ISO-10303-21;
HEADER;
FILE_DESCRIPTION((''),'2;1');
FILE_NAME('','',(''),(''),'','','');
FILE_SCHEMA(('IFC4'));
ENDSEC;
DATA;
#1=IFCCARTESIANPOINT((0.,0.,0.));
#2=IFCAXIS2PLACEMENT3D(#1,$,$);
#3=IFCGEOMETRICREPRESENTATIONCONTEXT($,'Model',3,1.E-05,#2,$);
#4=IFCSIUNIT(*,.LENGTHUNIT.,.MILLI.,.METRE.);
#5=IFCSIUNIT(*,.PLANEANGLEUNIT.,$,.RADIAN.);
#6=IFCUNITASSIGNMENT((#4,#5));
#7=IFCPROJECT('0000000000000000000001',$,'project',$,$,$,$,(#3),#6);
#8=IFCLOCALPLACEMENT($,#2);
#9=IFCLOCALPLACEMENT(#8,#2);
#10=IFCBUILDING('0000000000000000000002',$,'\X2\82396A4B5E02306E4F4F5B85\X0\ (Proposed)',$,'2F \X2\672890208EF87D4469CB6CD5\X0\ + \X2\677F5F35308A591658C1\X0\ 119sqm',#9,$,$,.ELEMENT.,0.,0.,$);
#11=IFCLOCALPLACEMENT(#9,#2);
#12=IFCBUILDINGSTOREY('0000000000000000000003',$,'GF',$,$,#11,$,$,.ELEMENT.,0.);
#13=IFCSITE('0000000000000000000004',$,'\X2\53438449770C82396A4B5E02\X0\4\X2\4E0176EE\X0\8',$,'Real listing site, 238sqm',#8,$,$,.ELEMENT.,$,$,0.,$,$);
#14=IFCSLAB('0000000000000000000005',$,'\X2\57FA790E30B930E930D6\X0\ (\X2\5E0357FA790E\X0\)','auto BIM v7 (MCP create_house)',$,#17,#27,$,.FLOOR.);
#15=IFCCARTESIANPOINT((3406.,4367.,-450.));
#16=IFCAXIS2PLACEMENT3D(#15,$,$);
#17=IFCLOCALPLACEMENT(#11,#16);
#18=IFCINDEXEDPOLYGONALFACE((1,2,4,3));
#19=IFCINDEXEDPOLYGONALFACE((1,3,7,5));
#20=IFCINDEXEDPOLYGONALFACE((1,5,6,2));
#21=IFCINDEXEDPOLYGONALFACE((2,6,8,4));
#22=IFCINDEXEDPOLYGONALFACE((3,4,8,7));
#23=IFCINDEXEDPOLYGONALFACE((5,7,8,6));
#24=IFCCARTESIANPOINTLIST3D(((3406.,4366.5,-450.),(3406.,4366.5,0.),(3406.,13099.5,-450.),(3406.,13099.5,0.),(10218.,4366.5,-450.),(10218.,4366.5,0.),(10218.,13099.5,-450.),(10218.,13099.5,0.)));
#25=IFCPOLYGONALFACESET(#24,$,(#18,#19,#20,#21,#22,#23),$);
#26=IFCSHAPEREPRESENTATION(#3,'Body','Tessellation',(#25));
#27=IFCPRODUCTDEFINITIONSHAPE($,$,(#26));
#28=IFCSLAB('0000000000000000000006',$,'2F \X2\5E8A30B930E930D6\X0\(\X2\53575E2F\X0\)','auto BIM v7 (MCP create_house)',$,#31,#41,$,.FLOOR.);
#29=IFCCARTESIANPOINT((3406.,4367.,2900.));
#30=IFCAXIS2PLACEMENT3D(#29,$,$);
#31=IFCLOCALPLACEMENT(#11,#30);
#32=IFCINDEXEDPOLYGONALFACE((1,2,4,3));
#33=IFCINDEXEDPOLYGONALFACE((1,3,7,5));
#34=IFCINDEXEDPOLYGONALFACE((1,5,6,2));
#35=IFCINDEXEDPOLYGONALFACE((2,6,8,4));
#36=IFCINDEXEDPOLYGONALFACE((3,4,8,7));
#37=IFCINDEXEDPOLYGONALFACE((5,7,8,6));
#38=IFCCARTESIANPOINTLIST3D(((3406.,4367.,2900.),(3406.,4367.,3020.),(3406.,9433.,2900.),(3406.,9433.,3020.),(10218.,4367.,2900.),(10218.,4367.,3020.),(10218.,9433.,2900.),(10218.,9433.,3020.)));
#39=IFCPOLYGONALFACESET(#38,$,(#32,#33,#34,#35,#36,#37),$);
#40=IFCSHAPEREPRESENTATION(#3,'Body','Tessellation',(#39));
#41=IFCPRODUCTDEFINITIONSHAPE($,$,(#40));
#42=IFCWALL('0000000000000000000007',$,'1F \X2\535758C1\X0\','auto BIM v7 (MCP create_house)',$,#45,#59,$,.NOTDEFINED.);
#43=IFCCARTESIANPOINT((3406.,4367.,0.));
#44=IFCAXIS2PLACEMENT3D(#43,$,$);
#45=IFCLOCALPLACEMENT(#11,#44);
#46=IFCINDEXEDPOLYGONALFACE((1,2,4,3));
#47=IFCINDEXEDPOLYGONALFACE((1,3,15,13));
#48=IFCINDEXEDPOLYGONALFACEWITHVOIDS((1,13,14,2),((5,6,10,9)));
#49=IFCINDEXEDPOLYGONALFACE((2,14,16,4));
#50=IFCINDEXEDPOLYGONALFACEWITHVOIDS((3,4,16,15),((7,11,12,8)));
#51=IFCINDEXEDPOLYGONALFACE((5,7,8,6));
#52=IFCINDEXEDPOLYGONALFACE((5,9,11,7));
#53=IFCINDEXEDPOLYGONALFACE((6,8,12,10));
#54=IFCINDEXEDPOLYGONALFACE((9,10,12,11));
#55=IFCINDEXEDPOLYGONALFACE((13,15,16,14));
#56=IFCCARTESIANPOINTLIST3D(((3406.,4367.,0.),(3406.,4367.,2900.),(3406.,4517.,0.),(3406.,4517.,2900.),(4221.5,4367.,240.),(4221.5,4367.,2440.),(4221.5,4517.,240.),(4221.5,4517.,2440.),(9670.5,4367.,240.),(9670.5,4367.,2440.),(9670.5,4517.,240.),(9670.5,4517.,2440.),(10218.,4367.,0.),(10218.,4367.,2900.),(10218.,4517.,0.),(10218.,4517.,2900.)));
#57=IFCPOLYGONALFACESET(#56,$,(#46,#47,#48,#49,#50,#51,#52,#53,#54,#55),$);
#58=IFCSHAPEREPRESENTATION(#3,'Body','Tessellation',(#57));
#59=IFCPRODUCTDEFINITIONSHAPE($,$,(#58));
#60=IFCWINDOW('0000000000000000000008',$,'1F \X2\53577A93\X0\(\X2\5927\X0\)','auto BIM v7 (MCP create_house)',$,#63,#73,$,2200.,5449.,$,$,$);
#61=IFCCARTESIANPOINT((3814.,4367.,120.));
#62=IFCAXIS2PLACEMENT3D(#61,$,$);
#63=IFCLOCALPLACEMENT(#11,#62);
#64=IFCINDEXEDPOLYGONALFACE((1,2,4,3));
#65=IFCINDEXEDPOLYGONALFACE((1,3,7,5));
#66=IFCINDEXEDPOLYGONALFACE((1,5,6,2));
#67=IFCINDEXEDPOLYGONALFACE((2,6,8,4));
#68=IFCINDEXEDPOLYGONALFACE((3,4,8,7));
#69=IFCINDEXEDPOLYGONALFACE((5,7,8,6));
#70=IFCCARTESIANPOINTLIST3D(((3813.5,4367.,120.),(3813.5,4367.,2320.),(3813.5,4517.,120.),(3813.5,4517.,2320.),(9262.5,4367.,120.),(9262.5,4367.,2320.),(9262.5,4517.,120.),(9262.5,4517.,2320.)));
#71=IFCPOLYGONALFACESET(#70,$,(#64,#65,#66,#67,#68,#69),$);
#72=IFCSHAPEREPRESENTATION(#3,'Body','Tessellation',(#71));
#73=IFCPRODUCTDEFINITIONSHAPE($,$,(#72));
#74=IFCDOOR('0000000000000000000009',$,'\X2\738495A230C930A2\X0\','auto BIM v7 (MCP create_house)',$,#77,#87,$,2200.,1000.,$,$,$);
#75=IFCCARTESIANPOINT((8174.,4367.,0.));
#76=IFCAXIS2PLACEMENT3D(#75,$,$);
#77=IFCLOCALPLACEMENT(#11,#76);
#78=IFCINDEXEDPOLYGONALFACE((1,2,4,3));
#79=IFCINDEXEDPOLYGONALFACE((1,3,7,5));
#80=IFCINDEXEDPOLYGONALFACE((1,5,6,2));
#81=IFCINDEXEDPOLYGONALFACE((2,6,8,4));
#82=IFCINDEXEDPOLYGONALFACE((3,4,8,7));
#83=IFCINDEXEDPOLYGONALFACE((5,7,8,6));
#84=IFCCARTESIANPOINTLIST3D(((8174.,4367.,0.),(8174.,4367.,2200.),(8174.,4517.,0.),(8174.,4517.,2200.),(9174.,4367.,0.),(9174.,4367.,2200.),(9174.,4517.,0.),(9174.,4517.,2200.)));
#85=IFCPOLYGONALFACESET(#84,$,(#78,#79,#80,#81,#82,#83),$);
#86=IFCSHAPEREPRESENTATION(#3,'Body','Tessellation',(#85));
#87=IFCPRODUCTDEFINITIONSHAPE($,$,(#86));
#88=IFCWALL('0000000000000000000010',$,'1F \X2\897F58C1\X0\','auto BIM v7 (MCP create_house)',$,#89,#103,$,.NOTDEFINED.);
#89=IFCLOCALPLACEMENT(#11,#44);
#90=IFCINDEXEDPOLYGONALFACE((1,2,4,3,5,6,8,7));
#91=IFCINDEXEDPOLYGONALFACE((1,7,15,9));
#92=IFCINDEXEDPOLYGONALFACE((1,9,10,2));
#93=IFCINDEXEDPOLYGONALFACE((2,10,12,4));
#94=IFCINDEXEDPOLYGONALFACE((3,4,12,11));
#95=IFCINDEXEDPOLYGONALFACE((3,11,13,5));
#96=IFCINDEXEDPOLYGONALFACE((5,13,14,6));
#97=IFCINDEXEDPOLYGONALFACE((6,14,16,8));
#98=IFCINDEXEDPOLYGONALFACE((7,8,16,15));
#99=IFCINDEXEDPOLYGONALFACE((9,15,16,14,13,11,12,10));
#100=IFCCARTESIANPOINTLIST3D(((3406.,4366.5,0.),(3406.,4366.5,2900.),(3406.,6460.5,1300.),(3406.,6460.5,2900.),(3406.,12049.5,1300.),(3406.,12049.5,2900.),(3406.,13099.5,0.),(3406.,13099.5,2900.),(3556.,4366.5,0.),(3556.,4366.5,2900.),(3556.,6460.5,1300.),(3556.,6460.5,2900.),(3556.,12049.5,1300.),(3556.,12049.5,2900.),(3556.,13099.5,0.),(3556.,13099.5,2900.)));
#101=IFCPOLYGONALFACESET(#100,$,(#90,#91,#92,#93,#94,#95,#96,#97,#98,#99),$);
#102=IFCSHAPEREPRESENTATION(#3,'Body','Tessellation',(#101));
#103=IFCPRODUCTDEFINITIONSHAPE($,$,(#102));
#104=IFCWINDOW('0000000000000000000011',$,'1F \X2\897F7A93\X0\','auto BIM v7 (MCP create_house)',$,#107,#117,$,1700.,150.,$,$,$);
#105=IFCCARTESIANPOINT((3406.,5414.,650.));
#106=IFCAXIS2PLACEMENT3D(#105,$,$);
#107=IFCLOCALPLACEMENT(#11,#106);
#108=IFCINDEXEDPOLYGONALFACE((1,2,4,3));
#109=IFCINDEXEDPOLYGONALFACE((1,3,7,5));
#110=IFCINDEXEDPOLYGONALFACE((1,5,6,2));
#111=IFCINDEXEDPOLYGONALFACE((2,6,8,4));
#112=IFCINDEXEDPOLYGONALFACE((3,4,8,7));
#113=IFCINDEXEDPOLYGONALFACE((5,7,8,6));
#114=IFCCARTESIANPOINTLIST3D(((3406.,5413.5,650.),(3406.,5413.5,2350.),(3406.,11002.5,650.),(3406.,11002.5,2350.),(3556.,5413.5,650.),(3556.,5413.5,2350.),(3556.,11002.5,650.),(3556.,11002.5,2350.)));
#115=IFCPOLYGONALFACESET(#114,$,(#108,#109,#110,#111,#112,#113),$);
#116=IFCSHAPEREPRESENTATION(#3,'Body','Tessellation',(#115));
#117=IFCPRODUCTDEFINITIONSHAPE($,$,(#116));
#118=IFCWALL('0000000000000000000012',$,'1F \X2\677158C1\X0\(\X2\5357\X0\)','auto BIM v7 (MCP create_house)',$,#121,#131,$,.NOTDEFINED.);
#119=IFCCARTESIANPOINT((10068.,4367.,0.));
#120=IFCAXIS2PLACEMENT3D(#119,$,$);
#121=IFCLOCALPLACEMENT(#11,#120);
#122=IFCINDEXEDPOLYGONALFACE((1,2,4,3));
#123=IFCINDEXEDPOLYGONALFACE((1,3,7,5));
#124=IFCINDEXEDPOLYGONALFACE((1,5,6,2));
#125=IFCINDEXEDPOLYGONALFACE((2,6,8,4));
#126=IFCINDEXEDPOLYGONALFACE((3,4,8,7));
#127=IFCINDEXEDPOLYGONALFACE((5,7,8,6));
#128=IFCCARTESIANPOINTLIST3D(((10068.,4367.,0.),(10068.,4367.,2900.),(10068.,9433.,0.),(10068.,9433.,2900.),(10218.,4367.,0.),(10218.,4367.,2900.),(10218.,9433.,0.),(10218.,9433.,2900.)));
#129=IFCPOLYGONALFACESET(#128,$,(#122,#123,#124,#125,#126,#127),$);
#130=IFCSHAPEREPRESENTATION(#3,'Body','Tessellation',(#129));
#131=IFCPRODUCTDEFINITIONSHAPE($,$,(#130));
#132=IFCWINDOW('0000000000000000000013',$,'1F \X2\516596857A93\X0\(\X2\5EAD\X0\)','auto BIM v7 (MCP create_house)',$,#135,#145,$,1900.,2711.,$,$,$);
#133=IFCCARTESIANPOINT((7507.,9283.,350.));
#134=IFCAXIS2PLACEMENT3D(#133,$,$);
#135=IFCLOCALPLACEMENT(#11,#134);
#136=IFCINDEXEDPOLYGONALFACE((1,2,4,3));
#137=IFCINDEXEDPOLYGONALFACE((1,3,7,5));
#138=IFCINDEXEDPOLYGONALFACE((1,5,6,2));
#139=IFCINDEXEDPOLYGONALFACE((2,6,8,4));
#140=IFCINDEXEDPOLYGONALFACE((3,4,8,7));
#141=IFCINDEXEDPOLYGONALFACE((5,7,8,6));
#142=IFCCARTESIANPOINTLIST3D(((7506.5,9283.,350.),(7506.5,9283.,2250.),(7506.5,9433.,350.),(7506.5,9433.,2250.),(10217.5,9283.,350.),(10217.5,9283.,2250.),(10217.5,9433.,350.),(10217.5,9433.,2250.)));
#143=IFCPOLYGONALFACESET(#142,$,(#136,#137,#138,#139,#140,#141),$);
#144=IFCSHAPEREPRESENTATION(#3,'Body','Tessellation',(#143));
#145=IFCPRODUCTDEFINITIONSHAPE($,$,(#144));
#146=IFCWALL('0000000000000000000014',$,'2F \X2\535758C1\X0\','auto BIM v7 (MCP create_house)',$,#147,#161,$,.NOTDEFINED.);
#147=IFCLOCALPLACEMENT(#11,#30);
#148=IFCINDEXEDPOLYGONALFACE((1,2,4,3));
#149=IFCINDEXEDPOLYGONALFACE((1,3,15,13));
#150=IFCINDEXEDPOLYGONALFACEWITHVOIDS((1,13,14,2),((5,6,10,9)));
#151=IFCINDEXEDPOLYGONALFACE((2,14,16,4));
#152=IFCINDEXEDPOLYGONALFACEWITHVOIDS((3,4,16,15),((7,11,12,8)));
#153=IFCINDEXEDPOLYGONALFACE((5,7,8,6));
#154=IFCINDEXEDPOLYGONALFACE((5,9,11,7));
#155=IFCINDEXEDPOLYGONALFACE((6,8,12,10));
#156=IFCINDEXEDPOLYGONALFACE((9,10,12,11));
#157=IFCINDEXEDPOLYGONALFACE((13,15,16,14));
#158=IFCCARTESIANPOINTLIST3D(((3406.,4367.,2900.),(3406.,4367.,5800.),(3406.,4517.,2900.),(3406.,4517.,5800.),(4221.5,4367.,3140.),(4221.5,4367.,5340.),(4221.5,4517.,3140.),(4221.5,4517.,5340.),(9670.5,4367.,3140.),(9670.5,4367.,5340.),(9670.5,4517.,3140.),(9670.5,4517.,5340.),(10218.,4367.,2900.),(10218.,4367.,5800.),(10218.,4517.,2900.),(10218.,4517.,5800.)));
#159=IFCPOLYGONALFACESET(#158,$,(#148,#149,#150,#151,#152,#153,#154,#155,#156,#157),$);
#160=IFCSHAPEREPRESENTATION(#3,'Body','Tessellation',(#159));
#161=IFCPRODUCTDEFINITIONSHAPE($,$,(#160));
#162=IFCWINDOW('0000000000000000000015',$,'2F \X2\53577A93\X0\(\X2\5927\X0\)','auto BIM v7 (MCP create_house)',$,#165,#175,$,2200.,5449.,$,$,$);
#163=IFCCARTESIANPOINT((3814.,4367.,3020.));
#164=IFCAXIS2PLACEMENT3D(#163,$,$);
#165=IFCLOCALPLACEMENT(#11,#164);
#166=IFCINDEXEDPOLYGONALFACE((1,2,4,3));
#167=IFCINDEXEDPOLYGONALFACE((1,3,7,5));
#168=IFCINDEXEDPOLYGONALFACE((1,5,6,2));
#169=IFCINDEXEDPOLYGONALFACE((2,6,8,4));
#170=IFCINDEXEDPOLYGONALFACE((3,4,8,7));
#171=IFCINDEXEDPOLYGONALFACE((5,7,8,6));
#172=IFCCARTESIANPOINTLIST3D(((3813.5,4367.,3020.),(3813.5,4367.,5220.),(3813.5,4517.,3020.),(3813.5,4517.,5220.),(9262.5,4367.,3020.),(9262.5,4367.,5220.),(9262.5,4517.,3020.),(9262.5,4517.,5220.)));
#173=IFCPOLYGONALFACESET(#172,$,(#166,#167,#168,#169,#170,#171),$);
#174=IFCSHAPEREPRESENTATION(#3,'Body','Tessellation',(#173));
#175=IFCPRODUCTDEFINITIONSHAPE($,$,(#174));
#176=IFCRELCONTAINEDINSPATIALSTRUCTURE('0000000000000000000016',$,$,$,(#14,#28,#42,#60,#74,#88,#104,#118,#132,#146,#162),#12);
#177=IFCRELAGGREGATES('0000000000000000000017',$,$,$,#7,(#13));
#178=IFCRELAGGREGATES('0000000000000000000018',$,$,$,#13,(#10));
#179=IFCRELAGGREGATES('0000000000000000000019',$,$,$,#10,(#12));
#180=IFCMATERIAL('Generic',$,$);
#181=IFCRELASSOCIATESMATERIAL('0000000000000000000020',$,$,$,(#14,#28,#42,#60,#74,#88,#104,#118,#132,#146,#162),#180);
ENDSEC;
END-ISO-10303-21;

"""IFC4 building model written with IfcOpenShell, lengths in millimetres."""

from ifc_helpers import new_model, si_unit, frame, frame_2d, origin, place, context, project, spatial, rectangle, extrude, material, element, fill, save


model = new_model("IFC4")

# Units and contexts
model_context = context("Model", 3, precision=1e-05, world=origin())
ifc_project = project(units=[si_unit("LENGTHUNIT", "METRE", prefix="MILLI"), si_unit("PLANEANGLEUNIT", "RADIAN")], contexts=[model_context])

# Site, building, storey
site_placement = place(None, origin())
site = spatial("IfcSite", under=ifc_project, at=site_placement, Name="千葉県船橋市4丁目8", ObjectType="Real listing site, 238sqm", CompositionType="ELEMENT", RefElevation=0.0)
building_placement = place(site_placement, origin())
building = spatial("IfcBuilding", under=site, at=building_placement, Name="船橋市の住宅 (Proposed)", ObjectType="2F 木造軸組構法 + 板張り外壁 119sqm", CompositionType="ELEMENT", ElevationOfRefHeight=0.0, ElevationOfTerrain=0.0)
storey_placement = place(building_placement, origin())
storey = spatial("IfcBuildingStorey", under=building, at=storey_placement, Name="GF", CompositionType="ELEMENT", Elevation=0.0)

# Slabs
ifc_material = material(Name="Generic")
slab_1_placement = place(storey_placement, frame((3406.0, 4367.0, -450.0)))
element("IfcSlab", 1, at=slab_1_placement, inside=storey, material=ifc_material, Name="基礎スラブ (布基礎)", Description="auto BIM v7 (MCP create_house)", PredefinedType="FLOOR", context=model_context, shape_type="SweptSolid", body=[
    extrude(rectangle(XDim=6812.0, YDim=8733.0, at=frame_2d((3406.0, 4366.0))), frame((3406.0, 4367.0, -450.0)), (0.0, 0.0, 1.0), 450.0),
])
slab_2_placement = place(storey_placement, frame((3406.0, 4367.0, 2900.0)))
element("IfcSlab", 2, at=slab_2_placement, inside=storey, material=ifc_material, Name="2F 床スラブ(南帯)", Description="auto BIM v7 (MCP create_house)", PredefinedType="FLOOR", context=model_context, shape_type="SweptSolid", body=[
    extrude(rectangle(XDim=6812.0, YDim=5066.0, at=frame_2d((3406.0, 2533.0))), frame((3406.0, 4367.0, 2900.0)), (0.0, 0.0, 1.0), 120.0),
])

# Wall, openings, window, door
wall_1_placement = place(storey_placement, frame((3406.0, 4367.0, 0.0)))
wall_1 = element("IfcWall", 3, at=wall_1_placement, inside=storey, material=ifc_material, Name="1F 南壁", Description="auto BIM v7 (MCP create_house)", PredefinedType="NOTDEFINED", context=model_context, shape_type="SweptSolid", body=[
    extrude(rectangle(XDim=6812.0, YDim=150.0, at=frame_2d((3406.0, 75.0))), frame((3406.0, 4367.0, 0.0)), (0.0, 0.0, 1.0), 2900.0),
])
opening_1_placement = place(storey_placement, frame((3814.0, 4367.0, 120.0)))
opening_1 = element("IfcOpeningElement", 4, at=opening_1_placement, cuts=wall_1, PredefinedType="NOTDEFINED", context=model_context, shape_type="SweptSolid", body=[
    extrude(rectangle(XDim=5449.0, YDim=150.0, at=frame_2d((2724.0, 75.0))), frame((3814.0, 4367.0, 120.0)), (0.0, 0.0, 1.0), 2200.0),
])
opening_2_placement = place(storey_placement, frame((8174.0, 4367.0, 0.0)))
opening_2 = element("IfcOpeningElement", 5, at=opening_2_placement, cuts=wall_1, PredefinedType="NOTDEFINED", context=model_context, shape_type="SweptSolid", body=[
    extrude(rectangle(XDim=1000.0, YDim=150.0, at=frame_2d((500.0, 75.0))), frame((8174.0, 4367.0, 0.0)), (0.0, 0.0, 1.0), 2200.0),
])
window_1_placement = place(storey_placement, frame((3814.0, 4367.0, 120.0)))
window_1 = element("IfcWindow", 6, at=window_1_placement, inside=storey, material=ifc_material, Name="1F 南窓(大)", Description="auto BIM v7 (MCP create_house)", OverallHeight=2200.0, OverallWidth=5449.0, context=model_context, shape_type="SweptSolid", body=[
    extrude(rectangle(XDim=5449.0, YDim=150.0, at=frame_2d((2724.0, 75.0))), frame((3814.0, 4367.0, 120.0)), (0.0, 0.0, 1.0), 2200.0),
])
fill(opening_1, window_1)
door_placement = place(storey_placement, frame((8174.0, 4367.0, 0.0)))
door = element("IfcDoor", 7, at=door_placement, inside=storey, material=ifc_material, Name="玄関ドア", Description="auto BIM v7 (MCP create_house)", OverallHeight=2200.0, OverallWidth=1000.0, context=model_context, shape_type="SweptSolid", body=[
    extrude(rectangle(XDim=1000.0, YDim=150.0, at=frame_2d((500.0, 75.0))), frame((8174.0, 4367.0, 0.0)), (0.0, 0.0, 1.0), 2200.0),
])
fill(opening_2, door)

# Walls, openings, windows
wall_2_placement = place(storey_placement, frame((3406.0, 4367.0, 0.0)))
wall_2 = element("IfcWall", 8, at=wall_2_placement, inside=storey, material=ifc_material, Name="1F 西壁", Description="auto BIM v7 (MCP create_house)", PredefinedType="NOTDEFINED", context=model_context, shape_type="SweptSolid", body=[
    extrude(rectangle(XDim=150.0, YDim=8733.0, at=frame_2d((75.0, 4366.0))), frame((3406.0, 4367.0, 0.0)), (0.0, 0.0, 1.0), 2900.0),
])
opening_3_placement = place(storey_placement, frame((3406.0, 5414.0, 650.0)))
opening_3 = element("IfcOpeningElement", 9, at=opening_3_placement, cuts=wall_2, PredefinedType="NOTDEFINED", context=model_context, shape_type="SweptSolid", body=[
    extrude(rectangle(XDim=150.0, YDim=5589.0, at=frame_2d((75.0, 2794.0))), frame((3406.0, 5414.0, 650.0)), (0.0, 0.0, 1.0), 1700.0),
])
window_2_placement = place(storey_placement, frame((3406.0, 5414.0, 650.0)))
window_2 = element("IfcWindow", 10, at=window_2_placement, inside=storey, material=ifc_material, Name="1F 西窓", Description="auto BIM v7 (MCP create_house)", OverallHeight=1700.0, OverallWidth=150.0, context=model_context, shape_type="SweptSolid", body=[
    extrude(rectangle(XDim=150.0, YDim=5589.0, at=frame_2d((75.0, 2794.0))), frame((3406.0, 5414.0, 650.0)), (0.0, 0.0, 1.0), 1700.0),
])
fill(opening_3, window_2)
wall_3_placement = place(storey_placement, frame((10068.0, 4367.0, 0.0)))
wall_3 = element("IfcWall", 11, at=wall_3_placement, inside=storey, material=ifc_material, Name="1F 東壁(南)", Description="auto BIM v7 (MCP create_house)", PredefinedType="NOTDEFINED", context=model_context, shape_type="SweptSolid", body=[
    extrude(rectangle(XDim=150.0, YDim=5066.0, at=frame_2d((75.0, 2533.0))), frame((10068.0, 4367.0, 0.0)), (0.0, 0.0, 1.0), 2900.0),
])
opening_4_placement = place(storey_placement, frame((7507.0, 9283.0, 350.0)))
opening_4 = element("IfcOpeningElement", 12, at=opening_4_placement, cuts=wall_3, PredefinedType="NOTDEFINED", context=model_context, shape_type="SweptSolid", body=[
    extrude(rectangle(XDim=2711.0, YDim=150.0, at=frame_2d((1355.0, 75.0))), frame((7507.0, 9283.0, 350.0)), (0.0, 0.0, 1.0), 1900.0),
])
window_3_placement = place(storey_placement, frame((7507.0, 9283.0, 350.0)))
window_3 = element("IfcWindow", 13, at=window_3_placement, inside=storey, material=ifc_material, Name="1F 入隅窓(庭)", Description="auto BIM v7 (MCP create_house)", OverallHeight=1900.0, OverallWidth=2711.0, context=model_context, shape_type="SweptSolid", body=[
    extrude(rectangle(XDim=2711.0, YDim=150.0, at=frame_2d((1355.0, 75.0))), frame((7507.0, 9283.0, 350.0)), (0.0, 0.0, 1.0), 1900.0),
])
fill(opening_4, window_3)

# Wall, opening, window
wall_4_placement = place(storey_placement, frame((3406.0, 4367.0, 2900.0)))
wall_4 = element("IfcWall", 14, at=wall_4_placement, inside=storey, material=ifc_material, Name="2F 南壁", Description="auto BIM v7 (MCP create_house)", PredefinedType="NOTDEFINED", context=model_context, shape_type="SweptSolid", body=[
    extrude(rectangle(XDim=6812.0, YDim=150.0, at=frame_2d((3406.0, 75.0))), frame((3406.0, 4367.0, 2900.0)), (0.0, 0.0, 1.0), 2900.0),
])
opening_5_placement = place(storey_placement, frame((3814.0, 4367.0, 3020.0)))
opening_5 = element("IfcOpeningElement", 15, at=opening_5_placement, cuts=wall_4, PredefinedType="NOTDEFINED", context=model_context, shape_type="SweptSolid", body=[
    extrude(rectangle(XDim=5449.0, YDim=150.0, at=frame_2d((2724.0, 75.0))), frame((3814.0, 4367.0, 3020.0)), (0.0, 0.0, 1.0), 2200.0),
])
window_4_placement = place(storey_placement, frame((3814.0, 4367.0, 3020.0)))
window_4 = element("IfcWindow", 16, at=window_4_placement, inside=storey, material=ifc_material, Name="2F 南窓(大)", Description="auto BIM v7 (MCP create_house)", OverallHeight=2200.0, OverallWidth=5449.0, context=model_context, shape_type="SweptSolid", body=[
    extrude(rectangle(XDim=5449.0, YDim=150.0, at=frame_2d((2724.0, 75.0))), frame((3814.0, 4367.0, 3020.0)), (0.0, 0.0, 1.0), 2200.0),
])
fill(opening_5, window_4)

save(model, "model.ifc")
